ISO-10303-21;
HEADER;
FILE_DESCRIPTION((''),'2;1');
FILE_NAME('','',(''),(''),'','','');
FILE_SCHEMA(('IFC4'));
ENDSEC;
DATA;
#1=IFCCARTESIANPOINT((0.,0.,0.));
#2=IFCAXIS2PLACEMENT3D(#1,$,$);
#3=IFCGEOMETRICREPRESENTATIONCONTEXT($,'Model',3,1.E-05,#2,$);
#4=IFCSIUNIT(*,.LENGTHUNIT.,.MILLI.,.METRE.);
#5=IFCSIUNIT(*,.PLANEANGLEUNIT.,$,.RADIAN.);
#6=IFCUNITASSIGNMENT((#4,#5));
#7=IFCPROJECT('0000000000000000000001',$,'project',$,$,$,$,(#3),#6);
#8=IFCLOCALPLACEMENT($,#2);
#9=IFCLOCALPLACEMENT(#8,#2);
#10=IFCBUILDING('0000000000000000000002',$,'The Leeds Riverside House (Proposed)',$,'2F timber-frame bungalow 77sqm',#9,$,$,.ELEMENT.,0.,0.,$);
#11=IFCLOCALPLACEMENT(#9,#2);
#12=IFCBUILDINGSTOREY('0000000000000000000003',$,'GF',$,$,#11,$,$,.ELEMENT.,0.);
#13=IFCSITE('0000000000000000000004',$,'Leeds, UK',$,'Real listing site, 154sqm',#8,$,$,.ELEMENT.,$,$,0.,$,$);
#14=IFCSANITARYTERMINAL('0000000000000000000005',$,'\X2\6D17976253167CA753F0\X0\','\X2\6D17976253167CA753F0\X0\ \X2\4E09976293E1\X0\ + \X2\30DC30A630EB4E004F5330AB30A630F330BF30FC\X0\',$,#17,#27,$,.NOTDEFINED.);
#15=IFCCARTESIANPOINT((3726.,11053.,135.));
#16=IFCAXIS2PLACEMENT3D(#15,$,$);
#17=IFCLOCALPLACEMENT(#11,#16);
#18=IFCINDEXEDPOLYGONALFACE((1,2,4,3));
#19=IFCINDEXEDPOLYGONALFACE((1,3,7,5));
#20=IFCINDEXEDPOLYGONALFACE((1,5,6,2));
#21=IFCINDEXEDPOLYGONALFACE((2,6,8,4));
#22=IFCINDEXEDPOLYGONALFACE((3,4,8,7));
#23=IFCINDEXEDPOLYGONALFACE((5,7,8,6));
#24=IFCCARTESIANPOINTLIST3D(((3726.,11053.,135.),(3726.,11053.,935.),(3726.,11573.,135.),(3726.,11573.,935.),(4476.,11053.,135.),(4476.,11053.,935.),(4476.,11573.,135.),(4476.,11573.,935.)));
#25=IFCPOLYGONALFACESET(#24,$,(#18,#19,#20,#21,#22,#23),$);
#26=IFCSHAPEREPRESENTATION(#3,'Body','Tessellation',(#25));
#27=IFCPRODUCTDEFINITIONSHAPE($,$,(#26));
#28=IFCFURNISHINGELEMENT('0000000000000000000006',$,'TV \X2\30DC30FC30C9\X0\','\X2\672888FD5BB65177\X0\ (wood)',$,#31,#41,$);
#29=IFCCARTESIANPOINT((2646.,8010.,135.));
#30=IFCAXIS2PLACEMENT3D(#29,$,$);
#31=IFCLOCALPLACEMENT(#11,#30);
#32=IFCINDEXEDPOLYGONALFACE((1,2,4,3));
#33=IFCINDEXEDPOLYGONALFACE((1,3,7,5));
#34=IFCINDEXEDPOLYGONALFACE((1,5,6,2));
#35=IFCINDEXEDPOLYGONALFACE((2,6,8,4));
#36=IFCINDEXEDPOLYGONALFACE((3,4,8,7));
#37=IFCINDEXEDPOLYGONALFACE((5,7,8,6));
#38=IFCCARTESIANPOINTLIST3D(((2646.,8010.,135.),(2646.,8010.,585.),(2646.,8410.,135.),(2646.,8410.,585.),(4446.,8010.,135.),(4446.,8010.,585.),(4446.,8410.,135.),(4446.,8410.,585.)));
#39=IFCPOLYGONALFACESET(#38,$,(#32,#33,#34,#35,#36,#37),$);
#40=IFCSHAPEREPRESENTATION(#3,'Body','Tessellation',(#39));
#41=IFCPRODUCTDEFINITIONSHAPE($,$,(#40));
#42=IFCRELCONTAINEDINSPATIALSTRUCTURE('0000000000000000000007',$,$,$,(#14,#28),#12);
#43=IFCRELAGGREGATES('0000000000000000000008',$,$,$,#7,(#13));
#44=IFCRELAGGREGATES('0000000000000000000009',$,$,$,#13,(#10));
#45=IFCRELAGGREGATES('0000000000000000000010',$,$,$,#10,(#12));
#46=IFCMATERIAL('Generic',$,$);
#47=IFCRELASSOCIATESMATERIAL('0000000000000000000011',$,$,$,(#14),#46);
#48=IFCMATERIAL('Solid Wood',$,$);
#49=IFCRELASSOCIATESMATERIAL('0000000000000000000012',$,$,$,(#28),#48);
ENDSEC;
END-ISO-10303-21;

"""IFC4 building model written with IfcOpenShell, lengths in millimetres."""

from ifc_helpers import new_model, si_unit, frame, frame_2d, origin, place, context, project, spatial, rectangle, extrude, material, element, save


model = new_model("IFC4")

# Units and contexts
model_context = context("Model", 3, precision=1e-05, world=origin())
ifc_project = project(units=[si_unit("LENGTHUNIT", "METRE", prefix="MILLI"), si_unit("PLANEANGLEUNIT", "RADIAN")], contexts=[model_context])

# Site, building, storey
site_placement = place(None, origin())
site = spatial("IfcSite", under=ifc_project, at=site_placement, Name="Leeds, UK", ObjectType="Real listing site, 154sqm", CompositionType="ELEMENT", RefElevation=0.0)
building_placement = place(site_placement, origin())
building = spatial("IfcBuilding", under=site, at=building_placement, Name="The Leeds Riverside House (Proposed)", ObjectType="2F timber-frame bungalow 77sqm", CompositionType="ELEMENT", ElevationOfRefHeight=0.0, ElevationOfTerrain=0.0)
storey_placement = place(building_placement, origin())
storey = spatial("IfcBuildingStorey", under=building, at=storey_placement, Name="GF", CompositionType="ELEMENT", Elevation=0.0)

# Shared definitions
ifc_material_1 = material(Name="Solid Wood")

# Shared definitions
ifc_material_2 = material(Name="Generic")

# Sanitary terminal
sanitary_terminal_1_placement = place(storey_placement, frame((3726.0, 11053.0, 135.0)))
element("IfcSanitaryTerminal", 1, at=sanitary_terminal_1_placement, inside=storey, material=ifc_material_2, Name="洗面化粧台", Description="洗面化粧台 三面鏡 + ボウル一体カウンター", PredefinedType="NOTDEFINED", context=model_context, shape_type="SweptSolid", body=[
    extrude(rectangle(XDim=750.0, YDim=520.0, at=frame_2d((375.0, 260.0))), frame((3726.0, 11053.0, 135.0)), (0.0, 0.0, 1.0), 800.0),
])

# Furnishing element
furnishing_placement = place(storey_placement, frame((2646.0, 8010.0, 135.0)))
element("IfcFurnishingElement", 2, at=furnishing_placement, inside=storey, material=ifc_material_1, Name="TV ボード", Description="木製家具 (wood)", context=model_context, shape_type="SweptSolid", body=[
    extrude(rectangle(XDim=1800.0, YDim=400.0, at=frame_2d((900.0, 200.0))), frame((2646.0, 8010.0, 135.0)), (0.0, 0.0, 1.0), 450.0),
])

save(model, "model.ifc")
